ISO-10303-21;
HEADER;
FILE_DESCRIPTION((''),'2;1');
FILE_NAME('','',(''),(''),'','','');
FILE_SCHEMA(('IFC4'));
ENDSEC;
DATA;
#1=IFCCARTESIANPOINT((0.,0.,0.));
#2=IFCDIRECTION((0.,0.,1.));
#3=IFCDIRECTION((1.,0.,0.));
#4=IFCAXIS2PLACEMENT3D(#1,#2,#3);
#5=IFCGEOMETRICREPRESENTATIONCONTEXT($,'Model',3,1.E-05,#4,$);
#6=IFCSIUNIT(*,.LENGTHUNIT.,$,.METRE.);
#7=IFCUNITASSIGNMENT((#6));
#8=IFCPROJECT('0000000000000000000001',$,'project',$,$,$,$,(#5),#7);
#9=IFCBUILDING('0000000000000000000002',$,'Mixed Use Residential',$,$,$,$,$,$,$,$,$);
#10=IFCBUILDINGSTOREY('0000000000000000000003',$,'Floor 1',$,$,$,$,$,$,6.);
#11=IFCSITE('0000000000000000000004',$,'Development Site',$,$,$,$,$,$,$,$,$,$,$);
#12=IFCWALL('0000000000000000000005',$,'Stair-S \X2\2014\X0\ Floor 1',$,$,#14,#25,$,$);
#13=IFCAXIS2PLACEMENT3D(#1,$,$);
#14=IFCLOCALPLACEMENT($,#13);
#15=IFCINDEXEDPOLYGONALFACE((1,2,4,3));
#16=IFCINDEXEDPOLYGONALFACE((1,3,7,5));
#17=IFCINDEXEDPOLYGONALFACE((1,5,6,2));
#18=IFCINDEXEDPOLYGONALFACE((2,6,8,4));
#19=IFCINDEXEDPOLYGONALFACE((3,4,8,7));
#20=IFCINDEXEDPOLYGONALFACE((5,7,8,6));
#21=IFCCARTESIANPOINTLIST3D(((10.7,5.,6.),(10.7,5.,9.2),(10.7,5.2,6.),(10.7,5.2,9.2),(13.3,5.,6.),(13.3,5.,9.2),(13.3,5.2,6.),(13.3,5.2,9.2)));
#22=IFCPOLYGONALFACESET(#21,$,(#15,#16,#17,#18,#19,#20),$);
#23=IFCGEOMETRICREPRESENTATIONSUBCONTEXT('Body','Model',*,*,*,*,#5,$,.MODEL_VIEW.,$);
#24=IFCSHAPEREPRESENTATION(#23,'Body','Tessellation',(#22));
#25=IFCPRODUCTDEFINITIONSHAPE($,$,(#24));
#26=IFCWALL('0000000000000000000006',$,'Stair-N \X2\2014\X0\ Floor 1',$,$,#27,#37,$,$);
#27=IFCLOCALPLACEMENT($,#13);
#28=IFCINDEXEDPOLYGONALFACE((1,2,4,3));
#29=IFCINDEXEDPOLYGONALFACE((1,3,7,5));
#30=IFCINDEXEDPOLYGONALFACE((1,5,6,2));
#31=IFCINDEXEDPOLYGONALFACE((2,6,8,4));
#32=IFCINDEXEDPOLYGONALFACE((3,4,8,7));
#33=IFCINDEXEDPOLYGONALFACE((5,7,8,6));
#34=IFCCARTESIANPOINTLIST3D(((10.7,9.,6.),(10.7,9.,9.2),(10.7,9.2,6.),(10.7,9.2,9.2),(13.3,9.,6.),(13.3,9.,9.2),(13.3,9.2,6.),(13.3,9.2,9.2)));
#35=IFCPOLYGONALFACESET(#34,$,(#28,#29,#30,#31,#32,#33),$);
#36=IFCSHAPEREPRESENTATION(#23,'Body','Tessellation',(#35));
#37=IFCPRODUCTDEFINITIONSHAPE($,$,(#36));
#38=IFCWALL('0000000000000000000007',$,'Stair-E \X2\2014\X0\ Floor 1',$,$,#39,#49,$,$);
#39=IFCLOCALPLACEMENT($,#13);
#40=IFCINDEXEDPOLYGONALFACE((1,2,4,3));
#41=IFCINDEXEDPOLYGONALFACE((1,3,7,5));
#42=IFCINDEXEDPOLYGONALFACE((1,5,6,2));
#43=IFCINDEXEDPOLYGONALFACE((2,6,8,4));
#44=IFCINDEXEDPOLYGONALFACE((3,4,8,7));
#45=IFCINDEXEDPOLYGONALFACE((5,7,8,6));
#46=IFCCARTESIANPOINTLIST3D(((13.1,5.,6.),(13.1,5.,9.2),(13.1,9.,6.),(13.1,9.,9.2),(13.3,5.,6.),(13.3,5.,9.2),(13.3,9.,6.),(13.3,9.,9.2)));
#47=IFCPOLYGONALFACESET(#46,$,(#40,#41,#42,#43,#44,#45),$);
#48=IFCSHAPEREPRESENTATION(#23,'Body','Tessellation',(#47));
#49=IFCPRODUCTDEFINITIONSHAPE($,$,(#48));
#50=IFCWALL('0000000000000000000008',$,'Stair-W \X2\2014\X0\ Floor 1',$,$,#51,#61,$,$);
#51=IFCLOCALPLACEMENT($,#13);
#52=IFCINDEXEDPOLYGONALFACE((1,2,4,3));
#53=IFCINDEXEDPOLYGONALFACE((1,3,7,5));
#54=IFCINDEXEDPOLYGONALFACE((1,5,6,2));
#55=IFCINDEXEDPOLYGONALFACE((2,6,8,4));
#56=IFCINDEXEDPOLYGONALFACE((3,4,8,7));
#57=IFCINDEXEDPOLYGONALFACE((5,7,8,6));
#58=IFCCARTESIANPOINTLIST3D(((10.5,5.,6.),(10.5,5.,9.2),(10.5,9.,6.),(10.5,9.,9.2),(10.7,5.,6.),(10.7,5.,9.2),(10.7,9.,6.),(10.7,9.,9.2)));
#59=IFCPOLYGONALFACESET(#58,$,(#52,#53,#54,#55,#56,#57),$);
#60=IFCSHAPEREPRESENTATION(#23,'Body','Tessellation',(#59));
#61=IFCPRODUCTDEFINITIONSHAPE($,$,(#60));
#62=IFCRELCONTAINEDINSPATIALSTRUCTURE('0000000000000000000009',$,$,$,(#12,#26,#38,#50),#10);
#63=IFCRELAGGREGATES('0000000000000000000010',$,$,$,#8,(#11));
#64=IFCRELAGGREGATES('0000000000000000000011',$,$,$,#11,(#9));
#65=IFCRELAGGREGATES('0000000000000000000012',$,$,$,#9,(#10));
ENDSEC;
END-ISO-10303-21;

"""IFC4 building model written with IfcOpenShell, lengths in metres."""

from ifc_helpers import new_model, si_unit, frame, origin_with_axes, place, context, subcontext, project, spatial, indexed_curve, outline, extrude, element, save


model = new_model("IFC4")

# Units and contexts
model_context = context("Model", 3, precision=1e-05, world=origin_with_axes())
body_context = subcontext(model_context, "Body", "Model", "MODEL_VIEW")
ifc_project = project(units=[si_unit("LENGTHUNIT", "METRE")], contexts=[model_context])

# Site, building, storey
site = spatial("IfcSite", under=ifc_project, Name="Development Site")
building = spatial("IfcBuilding", under=site, Name="Mixed Use Residential")
storey = spatial("IfcBuildingStorey", under=building, Name="Floor 1", Elevation=6.0)

# Walls
for number, where, z_axis, x_axis, name in (
    (1, (10.7, 5.0, 6.0), (0.0, 0.0, 1.0), (1.0, 0.0, 0.0), "Stair-S — Floor 1"),
    (2, (10.7, 9.0, 6.0), (0.0, 0.0, 1.0), (1.0, 0.0, 0.0), "Stair-N — Floor 1"),
):
    element("IfcWall", number, at=place(None, frame(where, z_axis=z_axis, x_axis=x_axis)), inside=storey, Name=name, context=body_context, shape_type="SweptSolid", body=[
        extrude(outline(indexed_curve([(0.0, 0.0), (0.0, 0.2), (2.6, 0.2), (2.6, 0.0), (0.0, 0.0)], self_intersect=False)), origin_with_axes(), (0.0, 0.0, 1.0), 3.2),
    ])
for number, where, z_axis, x_axis, name in (
    (3, (13.3, 5.0, 6.0), (0.0, 0.0, 1.0), (0.0, 1.0, 0.0), "Stair-E — Floor 1"),
    (4, (10.7, 5.0, 6.0), (0.0, 0.0, 1.0), (0.0, 1.0, 0.0), "Stair-W — Floor 1"),
):
    element("IfcWall", number, at=place(None, frame(where, z_axis=z_axis, x_axis=x_axis)), inside=storey, Name=name, context=body_context, shape_type="SweptSolid", body=[
        extrude(outline(indexed_curve([(0.0, 0.0), (0.0, 0.2), (4.0, 0.2), (4.0, 0.0), (0.0, 0.0)], self_intersect=False)), origin_with_axes(), (0.0, 0.0, 1.0), 3.2),
    ])

save(model, "model.ifc")
